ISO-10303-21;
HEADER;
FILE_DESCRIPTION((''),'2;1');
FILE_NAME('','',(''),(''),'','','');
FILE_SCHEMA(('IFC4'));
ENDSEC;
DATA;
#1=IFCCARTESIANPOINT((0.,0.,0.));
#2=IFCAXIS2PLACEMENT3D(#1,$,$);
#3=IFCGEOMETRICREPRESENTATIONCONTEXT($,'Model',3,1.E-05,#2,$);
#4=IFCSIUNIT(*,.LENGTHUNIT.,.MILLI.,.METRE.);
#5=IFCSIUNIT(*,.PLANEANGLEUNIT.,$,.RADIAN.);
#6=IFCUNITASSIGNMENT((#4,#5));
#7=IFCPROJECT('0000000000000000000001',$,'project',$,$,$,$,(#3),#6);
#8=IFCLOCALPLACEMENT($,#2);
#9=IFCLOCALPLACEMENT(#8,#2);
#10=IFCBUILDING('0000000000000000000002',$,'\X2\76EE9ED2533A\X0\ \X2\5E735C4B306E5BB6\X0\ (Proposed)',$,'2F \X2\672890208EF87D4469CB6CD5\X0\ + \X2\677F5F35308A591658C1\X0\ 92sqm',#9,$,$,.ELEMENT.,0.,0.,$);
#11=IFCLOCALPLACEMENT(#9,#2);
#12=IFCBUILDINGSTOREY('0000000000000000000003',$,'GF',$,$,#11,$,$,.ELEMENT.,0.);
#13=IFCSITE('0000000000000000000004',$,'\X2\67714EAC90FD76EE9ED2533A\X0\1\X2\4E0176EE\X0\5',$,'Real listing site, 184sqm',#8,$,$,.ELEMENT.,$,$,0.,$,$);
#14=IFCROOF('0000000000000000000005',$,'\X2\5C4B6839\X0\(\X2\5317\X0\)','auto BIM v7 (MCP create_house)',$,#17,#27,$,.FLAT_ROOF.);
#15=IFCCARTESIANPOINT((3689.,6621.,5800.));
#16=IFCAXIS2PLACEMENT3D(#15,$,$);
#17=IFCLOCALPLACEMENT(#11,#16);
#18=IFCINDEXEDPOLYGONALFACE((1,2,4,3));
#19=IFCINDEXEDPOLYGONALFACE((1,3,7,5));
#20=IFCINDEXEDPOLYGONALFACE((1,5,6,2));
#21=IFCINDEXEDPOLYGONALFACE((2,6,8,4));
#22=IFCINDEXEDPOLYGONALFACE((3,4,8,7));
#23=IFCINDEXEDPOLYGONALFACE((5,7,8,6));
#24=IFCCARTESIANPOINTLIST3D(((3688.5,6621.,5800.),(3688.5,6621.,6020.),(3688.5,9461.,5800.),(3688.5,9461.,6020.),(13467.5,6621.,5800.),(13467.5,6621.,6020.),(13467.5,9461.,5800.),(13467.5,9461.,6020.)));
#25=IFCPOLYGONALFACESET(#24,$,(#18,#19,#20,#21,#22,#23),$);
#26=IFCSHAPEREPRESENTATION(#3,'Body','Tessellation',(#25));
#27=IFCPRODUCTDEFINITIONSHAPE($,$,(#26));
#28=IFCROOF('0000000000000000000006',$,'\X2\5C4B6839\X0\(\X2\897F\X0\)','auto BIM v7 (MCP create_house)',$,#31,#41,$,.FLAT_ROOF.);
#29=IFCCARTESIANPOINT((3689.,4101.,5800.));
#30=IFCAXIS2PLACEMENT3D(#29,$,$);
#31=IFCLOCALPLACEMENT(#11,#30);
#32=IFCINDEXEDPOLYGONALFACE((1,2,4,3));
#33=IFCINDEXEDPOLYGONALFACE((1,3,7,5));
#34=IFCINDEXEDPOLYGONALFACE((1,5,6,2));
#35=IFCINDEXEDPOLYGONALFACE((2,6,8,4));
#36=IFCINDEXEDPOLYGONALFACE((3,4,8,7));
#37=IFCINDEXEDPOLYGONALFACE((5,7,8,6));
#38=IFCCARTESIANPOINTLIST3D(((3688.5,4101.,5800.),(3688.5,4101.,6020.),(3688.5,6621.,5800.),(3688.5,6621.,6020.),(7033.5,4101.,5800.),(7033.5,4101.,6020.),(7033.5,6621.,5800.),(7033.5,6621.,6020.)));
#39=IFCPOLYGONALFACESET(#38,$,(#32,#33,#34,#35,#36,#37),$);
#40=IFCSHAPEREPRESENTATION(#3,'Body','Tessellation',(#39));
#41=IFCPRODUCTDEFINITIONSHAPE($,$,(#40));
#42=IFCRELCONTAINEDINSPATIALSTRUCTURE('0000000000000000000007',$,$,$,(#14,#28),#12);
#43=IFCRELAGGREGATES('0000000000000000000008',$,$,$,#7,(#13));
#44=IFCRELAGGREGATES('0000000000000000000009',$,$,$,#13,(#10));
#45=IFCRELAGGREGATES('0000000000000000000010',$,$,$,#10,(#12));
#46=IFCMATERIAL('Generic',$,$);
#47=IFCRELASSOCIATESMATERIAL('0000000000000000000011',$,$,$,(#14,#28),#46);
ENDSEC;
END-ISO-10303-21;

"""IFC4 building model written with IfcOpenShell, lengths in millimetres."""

from ifc_helpers import new_model, si_unit, frame, frame_2d, origin, place, context, project, spatial, rectangle, extrude, material, element, save


model = new_model("IFC4")

# Units and contexts
model_context = context("Model", 3, precision=1e-05, world=origin())
ifc_project = project(units=[si_unit("LENGTHUNIT", "METRE", prefix="MILLI"), si_unit("PLANEANGLEUNIT", "RADIAN")], contexts=[model_context])

# Site, building, storey
site_placement = place(None, origin())
site = spatial("IfcSite", under=ifc_project, at=site_placement, Name="東京都目黒区1丁目5", ObjectType="Real listing site, 184sqm", CompositionType="ELEMENT", RefElevation=0.0)
building_placement = place(site_placement, origin())
building = spatial("IfcBuilding", under=site, at=building_placement, Name="目黒区 平屋の家 (Proposed)", ObjectType="2F 木造軸組構法 + 板張り外壁 92sqm", CompositionType="ELEMENT", ElevationOfRefHeight=0.0, ElevationOfTerrain=0.0)
storey_placement = place(building_placement, origin())
storey = spatial("IfcBuildingStorey", under=building, at=storey_placement, Name="GF", CompositionType="ELEMENT", Elevation=0.0)

# Shared definitions
ifc_material = material(Name="Generic")

# Roofs
roof_1_placement = place(storey_placement, frame((3689.0, 6621.0, 5800.0)))
element("IfcRoof", 1, at=roof_1_placement, inside=storey, material=ifc_material, Name="屋根(北)", Description="auto BIM v7 (MCP create_house)", PredefinedType="FLAT_ROOF", context=model_context, shape_type="SweptSolid", body=[
    extrude(rectangle(XDim=9779.0, YDim=2840.0, at=frame_2d((4889.0, 1420.0))), frame((3689.0, 6621.0, 5800.0)), (0.0, 0.0, 1.0), 220.0),
])
roof_2_placement = place(storey_placement, frame((3689.0, 4101.0, 5800.0)))
element("IfcRoof", 2, at=roof_2_placement, inside=storey, material=ifc_material, Name="屋根(西)", Description="auto BIM v7 (MCP create_house)", PredefinedType="FLAT_ROOF", context=model_context, shape_type="SweptSolid", body=[
    extrude(rectangle(XDim=3345.0, YDim=2520.0, at=frame_2d((1672.0, 1260.0))), frame((3689.0, 4101.0, 5800.0)), (0.0, 0.0, 1.0), 220.0),
])

save(model, "model.ifc")
